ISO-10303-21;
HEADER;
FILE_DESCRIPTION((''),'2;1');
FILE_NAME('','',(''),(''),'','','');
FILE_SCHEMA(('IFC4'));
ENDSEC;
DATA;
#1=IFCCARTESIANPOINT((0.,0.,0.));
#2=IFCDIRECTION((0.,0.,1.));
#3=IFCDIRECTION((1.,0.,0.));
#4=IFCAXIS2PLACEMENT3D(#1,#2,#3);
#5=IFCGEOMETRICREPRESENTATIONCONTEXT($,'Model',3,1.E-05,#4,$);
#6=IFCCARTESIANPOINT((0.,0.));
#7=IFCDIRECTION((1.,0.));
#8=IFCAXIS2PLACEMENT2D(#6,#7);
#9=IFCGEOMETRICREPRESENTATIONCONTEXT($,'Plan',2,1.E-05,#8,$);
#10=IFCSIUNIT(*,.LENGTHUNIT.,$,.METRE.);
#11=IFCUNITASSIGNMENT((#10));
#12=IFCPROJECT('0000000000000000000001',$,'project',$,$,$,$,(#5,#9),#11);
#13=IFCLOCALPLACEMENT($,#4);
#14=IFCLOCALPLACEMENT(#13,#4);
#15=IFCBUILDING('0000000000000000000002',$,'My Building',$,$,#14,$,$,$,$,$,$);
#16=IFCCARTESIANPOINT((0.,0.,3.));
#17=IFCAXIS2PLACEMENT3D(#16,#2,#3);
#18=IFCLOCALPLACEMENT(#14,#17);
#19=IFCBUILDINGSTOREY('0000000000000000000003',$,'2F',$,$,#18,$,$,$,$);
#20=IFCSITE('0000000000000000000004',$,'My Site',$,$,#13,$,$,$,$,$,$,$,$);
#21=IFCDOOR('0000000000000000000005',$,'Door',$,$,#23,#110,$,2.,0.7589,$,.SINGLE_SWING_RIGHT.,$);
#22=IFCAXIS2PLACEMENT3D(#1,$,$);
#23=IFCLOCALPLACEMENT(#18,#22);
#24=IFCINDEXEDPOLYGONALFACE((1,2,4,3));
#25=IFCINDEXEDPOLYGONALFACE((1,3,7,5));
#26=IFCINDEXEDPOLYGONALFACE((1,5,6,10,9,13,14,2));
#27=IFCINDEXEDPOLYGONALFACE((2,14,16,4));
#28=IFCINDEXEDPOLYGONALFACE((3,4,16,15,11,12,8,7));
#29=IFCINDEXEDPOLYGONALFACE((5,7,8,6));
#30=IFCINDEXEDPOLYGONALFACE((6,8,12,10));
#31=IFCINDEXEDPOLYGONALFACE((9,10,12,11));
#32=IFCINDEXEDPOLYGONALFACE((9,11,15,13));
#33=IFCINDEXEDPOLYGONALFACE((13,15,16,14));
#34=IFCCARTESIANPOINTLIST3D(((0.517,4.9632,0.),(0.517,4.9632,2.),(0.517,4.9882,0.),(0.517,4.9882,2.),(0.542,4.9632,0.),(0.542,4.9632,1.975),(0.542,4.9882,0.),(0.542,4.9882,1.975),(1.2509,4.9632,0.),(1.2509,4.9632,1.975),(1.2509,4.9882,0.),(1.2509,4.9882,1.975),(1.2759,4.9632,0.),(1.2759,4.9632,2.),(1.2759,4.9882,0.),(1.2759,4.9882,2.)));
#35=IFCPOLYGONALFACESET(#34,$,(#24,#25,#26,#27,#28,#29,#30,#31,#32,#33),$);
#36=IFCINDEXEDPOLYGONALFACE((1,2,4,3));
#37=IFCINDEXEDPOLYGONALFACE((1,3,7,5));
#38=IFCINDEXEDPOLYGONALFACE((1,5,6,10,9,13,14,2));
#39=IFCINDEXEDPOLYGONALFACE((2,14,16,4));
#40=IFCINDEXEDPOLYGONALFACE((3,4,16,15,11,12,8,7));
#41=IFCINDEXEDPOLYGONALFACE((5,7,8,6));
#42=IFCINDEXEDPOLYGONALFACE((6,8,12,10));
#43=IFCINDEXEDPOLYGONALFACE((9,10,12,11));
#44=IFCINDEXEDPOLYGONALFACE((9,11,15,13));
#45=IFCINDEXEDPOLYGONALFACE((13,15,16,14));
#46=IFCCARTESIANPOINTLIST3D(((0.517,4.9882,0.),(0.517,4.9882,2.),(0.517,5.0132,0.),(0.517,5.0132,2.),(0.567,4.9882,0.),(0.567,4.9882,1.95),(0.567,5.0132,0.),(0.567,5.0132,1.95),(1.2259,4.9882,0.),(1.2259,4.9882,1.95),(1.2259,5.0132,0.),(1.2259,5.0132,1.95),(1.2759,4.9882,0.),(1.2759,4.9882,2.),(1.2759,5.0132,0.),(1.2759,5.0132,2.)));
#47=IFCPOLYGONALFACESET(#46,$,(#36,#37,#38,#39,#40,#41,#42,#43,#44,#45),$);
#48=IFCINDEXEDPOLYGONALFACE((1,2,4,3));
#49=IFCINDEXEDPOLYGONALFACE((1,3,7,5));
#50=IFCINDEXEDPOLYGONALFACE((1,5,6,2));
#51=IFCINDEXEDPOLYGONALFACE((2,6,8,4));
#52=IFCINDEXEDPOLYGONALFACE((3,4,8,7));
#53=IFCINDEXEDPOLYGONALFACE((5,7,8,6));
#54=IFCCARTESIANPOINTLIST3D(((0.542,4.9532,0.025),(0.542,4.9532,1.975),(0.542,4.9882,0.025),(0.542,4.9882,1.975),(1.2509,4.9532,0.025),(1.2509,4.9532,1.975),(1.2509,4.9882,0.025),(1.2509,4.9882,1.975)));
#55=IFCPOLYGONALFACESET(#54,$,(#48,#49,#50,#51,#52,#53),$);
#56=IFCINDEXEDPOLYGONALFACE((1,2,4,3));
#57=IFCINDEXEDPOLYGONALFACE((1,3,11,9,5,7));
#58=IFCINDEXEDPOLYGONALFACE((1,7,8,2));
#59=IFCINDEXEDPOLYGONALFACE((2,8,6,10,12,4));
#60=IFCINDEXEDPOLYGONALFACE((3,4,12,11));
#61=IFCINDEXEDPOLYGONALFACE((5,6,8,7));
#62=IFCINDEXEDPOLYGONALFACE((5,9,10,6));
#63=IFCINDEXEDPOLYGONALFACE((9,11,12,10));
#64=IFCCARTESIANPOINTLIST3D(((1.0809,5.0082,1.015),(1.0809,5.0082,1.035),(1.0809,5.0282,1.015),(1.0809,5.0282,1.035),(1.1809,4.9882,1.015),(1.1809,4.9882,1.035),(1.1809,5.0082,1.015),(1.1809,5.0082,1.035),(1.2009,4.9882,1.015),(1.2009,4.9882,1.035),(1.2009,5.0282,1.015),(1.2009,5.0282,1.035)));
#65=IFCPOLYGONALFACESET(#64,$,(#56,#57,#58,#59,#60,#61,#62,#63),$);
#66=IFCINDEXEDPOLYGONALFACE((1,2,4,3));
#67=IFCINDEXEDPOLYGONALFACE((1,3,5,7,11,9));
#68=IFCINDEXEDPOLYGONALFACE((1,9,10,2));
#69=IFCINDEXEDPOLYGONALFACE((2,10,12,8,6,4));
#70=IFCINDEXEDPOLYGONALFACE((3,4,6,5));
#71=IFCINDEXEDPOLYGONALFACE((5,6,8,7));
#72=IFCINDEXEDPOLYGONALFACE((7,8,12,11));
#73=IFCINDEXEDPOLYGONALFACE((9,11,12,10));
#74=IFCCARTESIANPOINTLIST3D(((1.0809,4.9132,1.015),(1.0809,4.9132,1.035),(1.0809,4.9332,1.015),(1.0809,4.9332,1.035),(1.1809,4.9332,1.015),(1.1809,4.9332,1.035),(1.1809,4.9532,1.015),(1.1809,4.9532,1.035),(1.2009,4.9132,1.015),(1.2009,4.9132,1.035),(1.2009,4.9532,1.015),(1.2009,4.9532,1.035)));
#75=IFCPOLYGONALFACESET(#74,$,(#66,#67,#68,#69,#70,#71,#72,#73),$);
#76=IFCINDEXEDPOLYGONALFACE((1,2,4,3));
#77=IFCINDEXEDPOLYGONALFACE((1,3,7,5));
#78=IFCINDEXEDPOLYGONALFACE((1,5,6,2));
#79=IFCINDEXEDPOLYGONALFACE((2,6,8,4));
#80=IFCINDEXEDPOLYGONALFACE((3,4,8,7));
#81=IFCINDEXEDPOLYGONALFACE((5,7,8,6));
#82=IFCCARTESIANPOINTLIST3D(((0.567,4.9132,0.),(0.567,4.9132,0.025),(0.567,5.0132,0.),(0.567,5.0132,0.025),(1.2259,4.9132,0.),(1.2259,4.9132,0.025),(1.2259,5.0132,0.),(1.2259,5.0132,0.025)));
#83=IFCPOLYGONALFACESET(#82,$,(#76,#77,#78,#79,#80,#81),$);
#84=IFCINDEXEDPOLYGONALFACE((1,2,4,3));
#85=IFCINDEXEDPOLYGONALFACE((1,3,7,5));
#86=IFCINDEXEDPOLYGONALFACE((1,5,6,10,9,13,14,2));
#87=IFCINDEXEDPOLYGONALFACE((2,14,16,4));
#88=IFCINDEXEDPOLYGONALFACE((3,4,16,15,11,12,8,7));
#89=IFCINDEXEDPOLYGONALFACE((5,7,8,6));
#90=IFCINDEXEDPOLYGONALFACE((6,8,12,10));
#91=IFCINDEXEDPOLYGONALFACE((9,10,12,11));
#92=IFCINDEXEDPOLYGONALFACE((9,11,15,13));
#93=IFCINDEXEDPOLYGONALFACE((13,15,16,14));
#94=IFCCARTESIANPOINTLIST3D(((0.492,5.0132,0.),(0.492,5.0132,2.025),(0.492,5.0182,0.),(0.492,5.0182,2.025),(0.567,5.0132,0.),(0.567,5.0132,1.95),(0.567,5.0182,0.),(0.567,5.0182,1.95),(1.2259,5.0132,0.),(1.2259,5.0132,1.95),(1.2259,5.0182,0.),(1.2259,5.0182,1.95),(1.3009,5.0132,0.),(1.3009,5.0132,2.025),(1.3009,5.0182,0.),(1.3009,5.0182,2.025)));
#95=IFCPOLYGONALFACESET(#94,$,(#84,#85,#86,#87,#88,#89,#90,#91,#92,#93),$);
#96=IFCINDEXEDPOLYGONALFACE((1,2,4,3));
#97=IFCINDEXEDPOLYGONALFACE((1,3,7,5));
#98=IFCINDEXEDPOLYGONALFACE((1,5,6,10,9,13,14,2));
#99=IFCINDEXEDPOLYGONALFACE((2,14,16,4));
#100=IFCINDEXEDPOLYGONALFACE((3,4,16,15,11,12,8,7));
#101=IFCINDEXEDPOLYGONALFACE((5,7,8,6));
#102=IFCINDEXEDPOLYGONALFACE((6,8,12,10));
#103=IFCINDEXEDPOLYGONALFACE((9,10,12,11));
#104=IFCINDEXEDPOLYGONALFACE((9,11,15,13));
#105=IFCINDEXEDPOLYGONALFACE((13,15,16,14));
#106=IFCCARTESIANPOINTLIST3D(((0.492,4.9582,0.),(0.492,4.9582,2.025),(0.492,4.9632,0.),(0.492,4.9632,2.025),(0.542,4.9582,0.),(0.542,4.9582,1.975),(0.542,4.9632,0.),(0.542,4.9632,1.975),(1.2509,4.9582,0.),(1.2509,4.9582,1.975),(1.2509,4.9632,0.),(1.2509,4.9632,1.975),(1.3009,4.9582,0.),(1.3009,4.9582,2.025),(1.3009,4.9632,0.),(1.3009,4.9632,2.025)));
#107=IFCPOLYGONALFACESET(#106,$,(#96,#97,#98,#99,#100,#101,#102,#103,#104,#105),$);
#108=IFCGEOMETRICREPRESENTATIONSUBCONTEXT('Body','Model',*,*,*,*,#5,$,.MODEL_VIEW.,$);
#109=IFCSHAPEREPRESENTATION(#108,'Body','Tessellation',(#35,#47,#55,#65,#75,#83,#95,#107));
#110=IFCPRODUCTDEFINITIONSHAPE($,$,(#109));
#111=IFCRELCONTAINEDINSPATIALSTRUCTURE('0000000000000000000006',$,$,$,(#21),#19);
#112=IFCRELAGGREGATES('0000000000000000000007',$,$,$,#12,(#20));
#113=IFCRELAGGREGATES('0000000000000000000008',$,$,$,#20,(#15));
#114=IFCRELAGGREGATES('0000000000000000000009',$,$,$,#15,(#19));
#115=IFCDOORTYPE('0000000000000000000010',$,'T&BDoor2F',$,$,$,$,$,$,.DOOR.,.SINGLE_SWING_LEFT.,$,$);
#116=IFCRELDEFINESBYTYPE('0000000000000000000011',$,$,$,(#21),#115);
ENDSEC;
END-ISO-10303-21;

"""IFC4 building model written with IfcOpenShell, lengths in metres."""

from ifc_helpers import new_model, entity, si_unit, frame, origin_with_axes, origin_2d_with_axis, place, context, subcontext, project, spatial, line, indexed_curve, outline, extrude, shape, source, transform, mapped, type_object, type_shapes, element, save


model = new_model("IFC4")

# Units and contexts
model_context = context("Model", 3, precision=1e-05, world=origin_with_axes())
plan_context = context("Plan", 2, precision=1e-05, world=origin_2d_with_axis())
body_context_1 = subcontext(model_context, "Body", "Model", "MODEL_VIEW")
body_context_2 = subcontext(plan_context, "Body", "Plan", "PLAN_VIEW")
ifc_project = project(units=[si_unit("LENGTHUNIT", "METRE")], contexts=[model_context, plan_context])

# Site, building, storey
site_placement = place(None, origin_with_axes())
site = spatial("IfcSite", under=ifc_project, at=site_placement, Name="My Site")
building_placement = place(site_placement, origin_with_axes())
building = spatial("IfcBuilding", under=site, at=building_placement, Name="My Building")
storey_placement = place(building_placement, frame((0.0, 0.0, 3.0), z_axis=(0.0, 0.0, 1.0), x_axis=(1.0, 0.0, 0.0)))
storey = spatial("IfcBuildingStorey", under=building, at=storey_placement, Name="2F")

# Shared definitions
door_type_1 = type_object("IfcDoorType", Name="T&BDoor2F", OperationType="SINGLE_SWING_LEFT", PredefinedType="DOOR")
shared_shape_1 = source(origin_with_axes(), body_context_1, "Body", "SweptSolid", [
    extrude(outline(indexed_curve([(0.0, 0.0), (0.0, 2.0), (0.7589, 2.0), (0.7589, 0.0), (0.7339, 0.0), (0.7339, 1.975), (0.025, 1.975), (0.025, 0.0)], segments=[line(1, 2, 3, 4, 5, 6, 7, 8, 1)])), frame((0.0, 0.025, 0.0), z_axis=(0.0, -1.0, 0.0), x_axis=(1.0, 0.0, 0.0)), (0.0, 0.0, -1.0), 0.025),
    extrude(outline(indexed_curve([(0.0, 0.0), (0.0, 2.0), (0.7589, 2.0), (0.7589, 0.0), (0.7089, 0.0), (0.7089, 1.95), (0.05, 1.95), (0.05, 0.0)], segments=[line(1, 2, 3, 4, 5, 6, 7, 8, 1)])), frame((0.0, 0.0, 0.0), z_axis=(0.0, -1.0, 0.0), x_axis=(1.0, 0.0, 0.0)), (0.0, 0.0, -1.0), 0.025),
    extrude(outline(indexed_curve([(0.0, 0.0), (0.7089, 0.0), (0.7089, 0.035), (0.0, 0.035)], segments=[line(1, 2, 3, 4, 1)])), frame((0.025, 0.025, 0.025), z_axis=(0.0, 0.0, 1.0), x_axis=(1.0, 0.0, 0.0)), (0.0, 0.0, 1.0), 1.95),
    extrude(outline(indexed_curve([(0.0, 0.0), (0.0, -0.04), (0.12, -0.04), (0.12, -0.02), (0.02, -0.02), (0.02, 0.0)], segments=[line(1, 2, 3, 4, 5, 6, 1)])), frame((0.075, 0.025, 1.015), z_axis=(0.0, 0.0, 1.0), x_axis=(1.0, 0.0, 0.0)), (0.0, 0.0, 1.0), 0.02),
    extrude(outline(indexed_curve([(0.0, 0.0), (0.0, 0.04), (0.12, 0.04), (0.12, 0.02), (0.02, 0.02), (0.02, 0.0)], segments=[line(1, 2, 3, 4, 5, 6, 1)])), frame((0.075, 0.06, 1.015), z_axis=(0.0, 0.0, 1.0), x_axis=(1.0, 0.0, 0.0)), (0.0, 0.0, 1.0), 0.02),
    extrude(outline(indexed_curve([(0.0, 0.0), (0.6589, 0.0), (0.6589, 0.1), (0.0, 0.1)], segments=[line(1, 2, 3, 4, 1)])), frame((0.05, 0.0, 0.0), z_axis=(0.0, 0.0, 1.0), x_axis=(1.0, 0.0, 0.0)), (0.0, 0.0, 1.0), 0.025),
    extrude(outline(indexed_curve([(0.0, 0.0), (0.0, 2.025), (0.8089, 2.025), (0.8089, 0.0), (0.7339, 0.0), (0.7339, 1.95), (0.075, 1.95), (0.075, 0.0)], segments=[line(1, 2, 3, 4, 5, 6, 7, 8, 1)])), frame((-0.025, -0.005, 0.0), z_axis=(0.0, -1.0, 0.0), x_axis=(1.0, 0.0, 0.0)), (0.0, 0.0, -1.0), 0.005),
    extrude(outline(indexed_curve([(0.0, 0.0), (0.0, 2.025), (0.8089, 2.025), (0.8089, 0.0), (0.7589, 0.0), (0.7589, 1.975), (0.05, 1.975), (0.05, 0.0)], segments=[line(1, 2, 3, 4, 5, 6, 7, 8, 1)])), frame((-0.025, 0.05, 0.0), z_axis=(0.0, -1.0, 0.0), x_axis=(1.0, 0.0, 0.0)), (0.0, 0.0, -1.0), 0.005),
])
shared_shape_2 = source(origin_with_axes(), body_context_2, "Body", "Curve2D", [
    entity("IfcIndexedPolyCurve", entity("IfcCartesianPointList2D", [[0.0, 0.0], [0.0, 0.05], [0.025, 0.05], [0.025, 0.025], [0.05, 0.025], [0.05, 0.0]]), [entity("IfcLineIndex", [1, 2, 3, 4, 5, 6, 1])]),
    entity("IfcIndexedPolyCurve", entity("IfcCartesianPointList2D", [[0.7589, 0.0], [0.7589, 0.05], [0.7339, 0.05], [0.7339, 0.025], [0.7089, 0.025], [0.7089, 0.0]]), [entity("IfcLineIndex", [1, 2, 3, 4, 5, 6, 1])]),
    entity("IfcTrimmedCurve", entity("IfcEllipse", entity("IfcAxis2Placement2D", entity("IfcCartesianPoint", [0.6989, 0.05]), entity("IfcDirection", [1.0, 0.0])), 0.6739, 0.7089), [entity("IfcCartesianPoint", [0.6989, 0.7589])], [entity("IfcCartesianPoint", [0.025, 0.05])], True, "CARTESIAN"),
    entity("IfcIndexedPolyCurve", entity("IfcCartesianPointList2D", [[0.7339, 0.05], [0.6989, 0.05], [0.6989, 0.7589], [0.7339, 0.7589]]), [entity("IfcLineIndex", [1, 2, 3, 4, 1])]),
])
type_shapes(door_type_1, [shared_shape_1, shared_shape_2])

# Door
door_1_placement = place(storey_placement, frame((1.2759, 5.0132, 0.0), z_axis=(0.0, 0.0, 1.0), x_axis=(-1.0, 0.0, 0.0)))
element("IfcDoor", 1, at=door_1_placement, inside=storey, type_object=door_type_1, Name="Door", OperationType="SINGLE_SWING_RIGHT", OverallHeight=2.0, OverallWidth=0.7589, shapes=[
    shape(body_context_1, "Body", "MappedRepresentation", [mapped(shared_shape_1, transform((0.0, 0.0, 0.0), x_axis=(1.0, 0.0, 0.0), y_axis=(0.0, 1.0, 0.0), z_axis=(0.0, 0.0, 1.0), scale=1.0))]),
    shape(body_context_2, "Body", "MappedRepresentation", [mapped(shared_shape_2, transform((0.0, 0.0, 0.0), x_axis=(1.0, 0.0, 0.0), y_axis=(0.0, 1.0, 0.0), z_axis=(0.0, 0.0, 1.0), scale=1.0))]),
])

save(model, "model.ifc")
